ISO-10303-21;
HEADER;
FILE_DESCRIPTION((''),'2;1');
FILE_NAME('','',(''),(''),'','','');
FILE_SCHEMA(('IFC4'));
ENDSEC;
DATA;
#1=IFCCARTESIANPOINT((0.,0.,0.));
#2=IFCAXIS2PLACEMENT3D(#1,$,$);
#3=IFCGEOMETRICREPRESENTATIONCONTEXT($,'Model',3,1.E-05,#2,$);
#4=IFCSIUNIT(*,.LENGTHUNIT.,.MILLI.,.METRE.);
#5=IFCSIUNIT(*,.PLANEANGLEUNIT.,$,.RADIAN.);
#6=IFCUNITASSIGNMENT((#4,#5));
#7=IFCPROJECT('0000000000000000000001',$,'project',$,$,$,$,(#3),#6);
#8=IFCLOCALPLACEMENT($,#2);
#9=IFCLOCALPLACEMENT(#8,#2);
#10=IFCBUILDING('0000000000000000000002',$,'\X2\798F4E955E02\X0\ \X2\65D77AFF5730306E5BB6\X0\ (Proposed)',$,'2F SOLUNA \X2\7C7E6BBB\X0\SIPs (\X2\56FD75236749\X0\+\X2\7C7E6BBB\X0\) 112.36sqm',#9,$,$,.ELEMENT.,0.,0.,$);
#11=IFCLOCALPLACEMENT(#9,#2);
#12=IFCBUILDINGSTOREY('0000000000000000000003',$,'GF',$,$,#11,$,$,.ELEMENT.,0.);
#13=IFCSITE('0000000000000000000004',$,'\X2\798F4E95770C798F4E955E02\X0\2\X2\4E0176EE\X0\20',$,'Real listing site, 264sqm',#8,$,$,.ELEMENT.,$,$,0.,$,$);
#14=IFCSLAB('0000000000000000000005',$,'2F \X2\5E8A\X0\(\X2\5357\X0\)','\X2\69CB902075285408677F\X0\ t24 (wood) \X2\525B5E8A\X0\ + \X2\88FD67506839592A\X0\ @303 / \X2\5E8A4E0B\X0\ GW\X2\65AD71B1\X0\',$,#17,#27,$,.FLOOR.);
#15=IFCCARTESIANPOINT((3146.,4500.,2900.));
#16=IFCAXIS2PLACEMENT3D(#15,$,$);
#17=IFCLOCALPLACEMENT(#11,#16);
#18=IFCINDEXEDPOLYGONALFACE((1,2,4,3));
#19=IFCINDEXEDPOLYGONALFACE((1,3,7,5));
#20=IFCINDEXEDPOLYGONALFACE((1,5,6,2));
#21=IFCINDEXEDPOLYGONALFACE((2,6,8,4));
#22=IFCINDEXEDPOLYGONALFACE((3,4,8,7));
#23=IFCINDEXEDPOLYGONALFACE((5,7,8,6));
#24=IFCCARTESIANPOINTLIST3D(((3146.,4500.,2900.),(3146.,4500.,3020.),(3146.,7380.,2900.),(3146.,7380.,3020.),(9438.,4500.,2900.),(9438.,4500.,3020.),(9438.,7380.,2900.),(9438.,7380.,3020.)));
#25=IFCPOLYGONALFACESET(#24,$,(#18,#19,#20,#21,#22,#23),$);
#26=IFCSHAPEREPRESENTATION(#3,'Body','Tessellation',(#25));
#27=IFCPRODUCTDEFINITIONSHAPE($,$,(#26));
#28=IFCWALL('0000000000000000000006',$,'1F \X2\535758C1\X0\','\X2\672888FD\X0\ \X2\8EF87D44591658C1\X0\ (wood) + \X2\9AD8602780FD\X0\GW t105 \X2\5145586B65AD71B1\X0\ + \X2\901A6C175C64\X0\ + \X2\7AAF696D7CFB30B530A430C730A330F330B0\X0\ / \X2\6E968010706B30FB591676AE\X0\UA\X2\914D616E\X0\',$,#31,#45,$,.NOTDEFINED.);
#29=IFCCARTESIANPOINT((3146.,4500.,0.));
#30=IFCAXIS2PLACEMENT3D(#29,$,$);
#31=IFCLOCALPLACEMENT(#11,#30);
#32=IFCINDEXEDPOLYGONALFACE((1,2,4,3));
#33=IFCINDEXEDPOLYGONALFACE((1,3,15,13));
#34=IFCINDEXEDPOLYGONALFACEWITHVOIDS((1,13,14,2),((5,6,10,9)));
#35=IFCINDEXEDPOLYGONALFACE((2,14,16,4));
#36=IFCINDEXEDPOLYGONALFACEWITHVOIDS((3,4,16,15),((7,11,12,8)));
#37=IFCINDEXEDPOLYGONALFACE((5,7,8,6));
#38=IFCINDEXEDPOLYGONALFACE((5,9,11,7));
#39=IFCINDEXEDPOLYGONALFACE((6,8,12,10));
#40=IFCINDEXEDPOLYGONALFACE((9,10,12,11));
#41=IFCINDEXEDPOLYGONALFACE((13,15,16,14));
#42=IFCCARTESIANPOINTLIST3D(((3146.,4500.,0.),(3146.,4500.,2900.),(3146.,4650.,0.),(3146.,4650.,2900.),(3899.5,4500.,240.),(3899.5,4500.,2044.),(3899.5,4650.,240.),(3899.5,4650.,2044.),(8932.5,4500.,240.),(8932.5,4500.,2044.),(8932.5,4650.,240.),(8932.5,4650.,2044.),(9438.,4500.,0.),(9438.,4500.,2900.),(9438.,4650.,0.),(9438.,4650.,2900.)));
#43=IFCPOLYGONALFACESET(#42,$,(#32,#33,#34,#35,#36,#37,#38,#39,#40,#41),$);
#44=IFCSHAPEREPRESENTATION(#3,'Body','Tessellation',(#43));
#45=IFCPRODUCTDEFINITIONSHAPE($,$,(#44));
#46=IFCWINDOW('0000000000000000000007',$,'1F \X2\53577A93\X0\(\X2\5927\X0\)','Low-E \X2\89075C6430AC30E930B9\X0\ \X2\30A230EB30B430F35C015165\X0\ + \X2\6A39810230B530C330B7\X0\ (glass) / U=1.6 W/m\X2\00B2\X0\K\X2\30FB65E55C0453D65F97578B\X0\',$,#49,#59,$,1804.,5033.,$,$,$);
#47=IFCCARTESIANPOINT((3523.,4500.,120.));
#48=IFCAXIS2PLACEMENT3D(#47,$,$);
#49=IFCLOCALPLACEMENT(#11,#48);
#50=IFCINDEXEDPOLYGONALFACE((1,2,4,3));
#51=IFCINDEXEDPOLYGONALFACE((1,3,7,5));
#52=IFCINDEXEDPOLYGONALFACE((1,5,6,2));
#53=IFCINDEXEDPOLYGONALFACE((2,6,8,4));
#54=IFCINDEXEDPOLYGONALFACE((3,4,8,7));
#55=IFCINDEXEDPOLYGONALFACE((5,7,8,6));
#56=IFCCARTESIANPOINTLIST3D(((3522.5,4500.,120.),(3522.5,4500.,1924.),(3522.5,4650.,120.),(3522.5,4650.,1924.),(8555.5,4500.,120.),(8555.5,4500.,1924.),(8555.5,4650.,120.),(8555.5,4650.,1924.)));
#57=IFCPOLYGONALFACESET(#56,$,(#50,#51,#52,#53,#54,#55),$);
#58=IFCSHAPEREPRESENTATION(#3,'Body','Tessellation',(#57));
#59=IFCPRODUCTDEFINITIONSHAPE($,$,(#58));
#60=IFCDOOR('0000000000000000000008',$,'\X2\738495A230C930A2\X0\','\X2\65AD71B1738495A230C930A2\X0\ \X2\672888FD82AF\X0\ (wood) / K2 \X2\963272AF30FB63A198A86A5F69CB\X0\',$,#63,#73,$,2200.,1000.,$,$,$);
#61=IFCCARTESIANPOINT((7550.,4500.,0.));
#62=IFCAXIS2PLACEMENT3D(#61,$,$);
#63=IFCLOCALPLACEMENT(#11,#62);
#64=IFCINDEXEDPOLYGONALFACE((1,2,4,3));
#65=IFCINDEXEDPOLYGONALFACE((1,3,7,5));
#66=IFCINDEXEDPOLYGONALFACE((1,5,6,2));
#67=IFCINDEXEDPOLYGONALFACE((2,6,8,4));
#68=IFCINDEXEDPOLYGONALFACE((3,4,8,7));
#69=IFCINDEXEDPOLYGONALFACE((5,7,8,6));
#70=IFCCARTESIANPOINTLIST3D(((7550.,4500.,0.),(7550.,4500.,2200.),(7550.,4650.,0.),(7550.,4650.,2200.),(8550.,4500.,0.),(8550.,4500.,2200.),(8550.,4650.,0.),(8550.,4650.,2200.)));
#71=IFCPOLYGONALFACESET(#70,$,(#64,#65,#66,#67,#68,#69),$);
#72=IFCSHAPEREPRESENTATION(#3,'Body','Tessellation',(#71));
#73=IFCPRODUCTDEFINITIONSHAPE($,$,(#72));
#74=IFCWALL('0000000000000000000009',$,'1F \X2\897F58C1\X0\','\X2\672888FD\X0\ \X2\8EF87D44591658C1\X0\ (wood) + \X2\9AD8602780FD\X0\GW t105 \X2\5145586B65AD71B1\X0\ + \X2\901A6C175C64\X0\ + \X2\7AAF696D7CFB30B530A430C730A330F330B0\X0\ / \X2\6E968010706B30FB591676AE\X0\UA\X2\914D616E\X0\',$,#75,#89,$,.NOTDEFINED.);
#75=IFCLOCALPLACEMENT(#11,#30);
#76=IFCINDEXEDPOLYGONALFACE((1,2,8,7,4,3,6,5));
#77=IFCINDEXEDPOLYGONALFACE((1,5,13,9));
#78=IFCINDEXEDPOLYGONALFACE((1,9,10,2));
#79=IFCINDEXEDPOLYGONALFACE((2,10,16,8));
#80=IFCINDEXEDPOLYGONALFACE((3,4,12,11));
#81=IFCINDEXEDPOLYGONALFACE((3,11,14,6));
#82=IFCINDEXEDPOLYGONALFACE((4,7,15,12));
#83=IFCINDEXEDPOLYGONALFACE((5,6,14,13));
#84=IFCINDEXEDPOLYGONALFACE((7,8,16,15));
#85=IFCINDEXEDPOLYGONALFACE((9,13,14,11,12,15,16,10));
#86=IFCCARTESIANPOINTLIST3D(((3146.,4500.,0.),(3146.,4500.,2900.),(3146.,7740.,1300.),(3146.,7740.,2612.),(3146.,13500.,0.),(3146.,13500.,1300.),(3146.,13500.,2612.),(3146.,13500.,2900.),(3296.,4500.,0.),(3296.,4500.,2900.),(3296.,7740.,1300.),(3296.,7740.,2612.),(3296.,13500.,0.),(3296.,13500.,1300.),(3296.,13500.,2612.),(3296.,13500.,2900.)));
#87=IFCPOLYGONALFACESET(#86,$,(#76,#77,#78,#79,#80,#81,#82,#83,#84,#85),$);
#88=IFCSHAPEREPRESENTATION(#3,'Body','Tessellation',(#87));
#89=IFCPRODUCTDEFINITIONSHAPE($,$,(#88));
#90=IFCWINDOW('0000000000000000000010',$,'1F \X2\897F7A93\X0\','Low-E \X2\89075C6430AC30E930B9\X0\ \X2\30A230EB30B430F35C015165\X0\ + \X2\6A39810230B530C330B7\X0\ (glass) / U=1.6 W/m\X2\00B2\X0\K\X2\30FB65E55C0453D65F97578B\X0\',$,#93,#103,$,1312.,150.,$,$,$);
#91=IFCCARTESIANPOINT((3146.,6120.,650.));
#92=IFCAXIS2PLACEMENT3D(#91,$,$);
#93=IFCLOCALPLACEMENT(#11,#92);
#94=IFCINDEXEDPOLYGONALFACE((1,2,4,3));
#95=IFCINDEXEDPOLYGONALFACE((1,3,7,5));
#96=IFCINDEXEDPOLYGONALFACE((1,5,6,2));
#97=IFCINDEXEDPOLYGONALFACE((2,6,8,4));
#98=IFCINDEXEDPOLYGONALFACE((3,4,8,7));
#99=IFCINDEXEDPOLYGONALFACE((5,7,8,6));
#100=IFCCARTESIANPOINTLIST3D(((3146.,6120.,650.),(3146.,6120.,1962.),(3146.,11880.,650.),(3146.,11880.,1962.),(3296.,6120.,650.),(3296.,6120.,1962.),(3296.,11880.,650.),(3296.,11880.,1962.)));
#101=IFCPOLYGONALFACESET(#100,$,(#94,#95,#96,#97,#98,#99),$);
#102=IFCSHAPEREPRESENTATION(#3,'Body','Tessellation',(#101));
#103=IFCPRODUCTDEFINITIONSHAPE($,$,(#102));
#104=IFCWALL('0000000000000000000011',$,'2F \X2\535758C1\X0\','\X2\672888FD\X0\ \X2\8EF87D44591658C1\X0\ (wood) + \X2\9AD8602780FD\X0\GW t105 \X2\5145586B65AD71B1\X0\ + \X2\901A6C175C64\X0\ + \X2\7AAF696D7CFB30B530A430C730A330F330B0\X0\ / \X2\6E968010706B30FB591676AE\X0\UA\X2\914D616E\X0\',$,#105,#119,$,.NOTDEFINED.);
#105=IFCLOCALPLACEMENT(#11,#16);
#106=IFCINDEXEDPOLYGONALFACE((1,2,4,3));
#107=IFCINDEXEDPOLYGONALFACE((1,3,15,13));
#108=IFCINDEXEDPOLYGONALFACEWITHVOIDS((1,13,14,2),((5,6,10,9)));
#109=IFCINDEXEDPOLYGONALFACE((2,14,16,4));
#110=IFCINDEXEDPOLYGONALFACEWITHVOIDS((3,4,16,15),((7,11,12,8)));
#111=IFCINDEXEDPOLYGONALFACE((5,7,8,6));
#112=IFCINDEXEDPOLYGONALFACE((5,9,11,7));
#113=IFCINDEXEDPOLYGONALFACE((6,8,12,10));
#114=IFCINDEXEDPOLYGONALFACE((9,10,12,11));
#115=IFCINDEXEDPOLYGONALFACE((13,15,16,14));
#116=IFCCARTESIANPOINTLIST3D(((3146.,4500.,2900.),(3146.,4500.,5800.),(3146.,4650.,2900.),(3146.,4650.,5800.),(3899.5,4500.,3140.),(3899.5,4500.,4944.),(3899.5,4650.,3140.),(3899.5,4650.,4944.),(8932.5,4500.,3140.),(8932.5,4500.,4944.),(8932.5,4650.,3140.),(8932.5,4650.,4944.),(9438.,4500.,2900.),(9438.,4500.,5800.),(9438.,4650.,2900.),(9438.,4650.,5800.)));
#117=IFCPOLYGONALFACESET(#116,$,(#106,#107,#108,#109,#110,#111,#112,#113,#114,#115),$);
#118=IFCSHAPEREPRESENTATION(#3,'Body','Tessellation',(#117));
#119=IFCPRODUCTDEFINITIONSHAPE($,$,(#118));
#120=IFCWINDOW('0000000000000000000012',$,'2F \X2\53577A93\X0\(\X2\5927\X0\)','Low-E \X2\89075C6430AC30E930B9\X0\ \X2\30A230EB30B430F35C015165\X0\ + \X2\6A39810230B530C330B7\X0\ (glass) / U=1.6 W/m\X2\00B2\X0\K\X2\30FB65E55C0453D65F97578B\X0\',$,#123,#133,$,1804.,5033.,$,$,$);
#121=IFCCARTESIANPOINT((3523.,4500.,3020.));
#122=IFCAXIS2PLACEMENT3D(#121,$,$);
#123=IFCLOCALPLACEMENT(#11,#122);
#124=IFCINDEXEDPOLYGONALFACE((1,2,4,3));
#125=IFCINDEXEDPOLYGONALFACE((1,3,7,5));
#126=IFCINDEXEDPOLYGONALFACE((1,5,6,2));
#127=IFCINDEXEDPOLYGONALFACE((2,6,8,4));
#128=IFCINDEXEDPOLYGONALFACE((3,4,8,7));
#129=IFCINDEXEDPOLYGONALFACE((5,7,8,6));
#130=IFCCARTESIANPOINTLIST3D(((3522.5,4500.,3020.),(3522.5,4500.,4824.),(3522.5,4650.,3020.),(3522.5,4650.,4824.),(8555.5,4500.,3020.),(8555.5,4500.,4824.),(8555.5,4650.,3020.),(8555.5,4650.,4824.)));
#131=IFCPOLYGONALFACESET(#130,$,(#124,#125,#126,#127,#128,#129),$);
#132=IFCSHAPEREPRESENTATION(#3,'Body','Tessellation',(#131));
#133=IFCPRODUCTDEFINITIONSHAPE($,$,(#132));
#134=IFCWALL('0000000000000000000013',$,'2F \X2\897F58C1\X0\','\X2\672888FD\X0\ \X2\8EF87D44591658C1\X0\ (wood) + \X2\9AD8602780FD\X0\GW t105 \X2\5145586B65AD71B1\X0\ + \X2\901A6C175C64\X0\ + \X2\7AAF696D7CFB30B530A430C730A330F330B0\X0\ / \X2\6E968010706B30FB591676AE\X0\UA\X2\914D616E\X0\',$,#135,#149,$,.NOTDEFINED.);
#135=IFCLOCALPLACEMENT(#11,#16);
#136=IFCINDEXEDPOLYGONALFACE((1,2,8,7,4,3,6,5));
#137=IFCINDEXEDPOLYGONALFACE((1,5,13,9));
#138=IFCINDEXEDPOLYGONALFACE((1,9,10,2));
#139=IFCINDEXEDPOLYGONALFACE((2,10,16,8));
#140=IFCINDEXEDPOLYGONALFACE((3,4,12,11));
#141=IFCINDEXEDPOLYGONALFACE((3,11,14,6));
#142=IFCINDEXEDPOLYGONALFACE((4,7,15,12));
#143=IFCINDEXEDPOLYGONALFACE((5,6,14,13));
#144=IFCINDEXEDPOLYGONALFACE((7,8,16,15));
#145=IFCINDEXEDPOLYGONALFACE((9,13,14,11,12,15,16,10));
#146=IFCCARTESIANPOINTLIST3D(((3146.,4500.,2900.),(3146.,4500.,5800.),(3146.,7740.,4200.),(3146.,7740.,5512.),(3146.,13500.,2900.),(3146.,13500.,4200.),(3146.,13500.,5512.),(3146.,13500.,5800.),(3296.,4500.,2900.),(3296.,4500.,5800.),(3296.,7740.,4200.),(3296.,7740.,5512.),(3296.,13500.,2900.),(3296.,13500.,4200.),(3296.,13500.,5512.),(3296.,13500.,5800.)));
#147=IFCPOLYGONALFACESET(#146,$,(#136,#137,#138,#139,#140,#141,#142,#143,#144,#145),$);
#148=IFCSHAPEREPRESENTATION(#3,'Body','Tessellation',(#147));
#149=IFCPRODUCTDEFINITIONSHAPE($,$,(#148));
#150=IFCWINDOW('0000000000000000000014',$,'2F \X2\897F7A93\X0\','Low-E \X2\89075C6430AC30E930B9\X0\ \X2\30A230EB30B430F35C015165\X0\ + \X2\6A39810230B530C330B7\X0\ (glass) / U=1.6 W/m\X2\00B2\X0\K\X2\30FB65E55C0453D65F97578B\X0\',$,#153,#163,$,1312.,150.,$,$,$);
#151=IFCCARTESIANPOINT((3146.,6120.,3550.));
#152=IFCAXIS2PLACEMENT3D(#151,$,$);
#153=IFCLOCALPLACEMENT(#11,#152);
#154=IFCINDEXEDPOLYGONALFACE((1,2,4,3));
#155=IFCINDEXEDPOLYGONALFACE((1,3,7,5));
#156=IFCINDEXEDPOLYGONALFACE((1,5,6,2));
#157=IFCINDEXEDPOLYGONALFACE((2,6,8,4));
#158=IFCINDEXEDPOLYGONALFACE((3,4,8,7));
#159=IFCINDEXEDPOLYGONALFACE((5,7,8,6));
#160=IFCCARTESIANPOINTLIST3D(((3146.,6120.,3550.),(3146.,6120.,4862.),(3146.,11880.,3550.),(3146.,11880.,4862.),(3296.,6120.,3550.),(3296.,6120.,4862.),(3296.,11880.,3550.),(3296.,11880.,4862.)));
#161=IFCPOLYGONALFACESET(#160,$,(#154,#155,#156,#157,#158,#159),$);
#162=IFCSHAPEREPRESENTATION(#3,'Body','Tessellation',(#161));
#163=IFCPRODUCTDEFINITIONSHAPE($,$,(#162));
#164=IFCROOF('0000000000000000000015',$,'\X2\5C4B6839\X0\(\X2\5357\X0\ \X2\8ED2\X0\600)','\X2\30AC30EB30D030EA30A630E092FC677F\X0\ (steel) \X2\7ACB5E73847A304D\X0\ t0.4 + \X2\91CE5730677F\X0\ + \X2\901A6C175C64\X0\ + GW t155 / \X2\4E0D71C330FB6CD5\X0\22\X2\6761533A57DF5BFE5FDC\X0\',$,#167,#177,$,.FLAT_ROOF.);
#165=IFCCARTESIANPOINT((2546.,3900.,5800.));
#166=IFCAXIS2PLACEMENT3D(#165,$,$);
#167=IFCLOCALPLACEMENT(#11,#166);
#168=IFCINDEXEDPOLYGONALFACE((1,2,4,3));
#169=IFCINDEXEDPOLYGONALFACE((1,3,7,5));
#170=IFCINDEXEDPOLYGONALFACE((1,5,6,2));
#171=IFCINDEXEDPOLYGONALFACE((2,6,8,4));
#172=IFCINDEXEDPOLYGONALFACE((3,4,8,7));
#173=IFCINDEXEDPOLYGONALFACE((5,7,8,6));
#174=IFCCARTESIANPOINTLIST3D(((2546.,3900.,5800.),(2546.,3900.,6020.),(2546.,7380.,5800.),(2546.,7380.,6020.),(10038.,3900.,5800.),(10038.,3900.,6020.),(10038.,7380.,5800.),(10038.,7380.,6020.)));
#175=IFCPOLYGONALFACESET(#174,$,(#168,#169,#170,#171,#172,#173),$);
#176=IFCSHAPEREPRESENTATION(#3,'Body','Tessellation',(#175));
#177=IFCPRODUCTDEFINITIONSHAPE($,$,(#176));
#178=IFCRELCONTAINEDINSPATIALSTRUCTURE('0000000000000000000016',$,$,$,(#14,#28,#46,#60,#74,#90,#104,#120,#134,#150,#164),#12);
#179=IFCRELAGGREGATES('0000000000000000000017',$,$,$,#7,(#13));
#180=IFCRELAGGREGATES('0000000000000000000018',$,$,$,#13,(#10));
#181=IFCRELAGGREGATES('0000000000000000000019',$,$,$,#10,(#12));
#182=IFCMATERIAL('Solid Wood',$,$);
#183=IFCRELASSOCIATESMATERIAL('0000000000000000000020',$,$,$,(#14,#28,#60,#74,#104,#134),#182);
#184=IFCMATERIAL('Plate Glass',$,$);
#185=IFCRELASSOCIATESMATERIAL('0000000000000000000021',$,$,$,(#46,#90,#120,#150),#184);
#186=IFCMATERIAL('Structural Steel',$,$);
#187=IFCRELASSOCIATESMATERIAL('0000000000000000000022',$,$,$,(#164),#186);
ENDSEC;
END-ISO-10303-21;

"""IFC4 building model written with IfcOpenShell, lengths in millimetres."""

from ifc_helpers import new_model, si_unit, frame, frame_2d, origin, place, context, project, spatial, rectangle, extrude, material, element, fill, save


model = new_model("IFC4")

# Units and contexts
model_context = context("Model", 3, precision=1e-05, world=origin())
ifc_project = project(units=[si_unit("LENGTHUNIT", "METRE", prefix="MILLI"), si_unit("PLANEANGLEUNIT", "RADIAN")], contexts=[model_context])

# Site, building, storey
site_placement = place(None, origin())
site = spatial("IfcSite", under=ifc_project, at=site_placement, Name="福井県福井市2丁目20", ObjectType="Real listing site, 264sqm", CompositionType="ELEMENT", RefElevation=0.0)
building_placement = place(site_placement, origin())
building = spatial("IfcBuilding", under=site, at=building_placement, Name="福井市 旗竿地の家 (Proposed)", ObjectType="2F SOLUNA 籾殻SIPs (国産杉+籾殻) 112.36sqm", CompositionType="ELEMENT", ElevationOfRefHeight=0.0, ElevationOfTerrain=0.0)
storey_placement = place(building_placement, origin())
storey = spatial("IfcBuildingStorey", under=building, at=storey_placement, Name="GF", CompositionType="ELEMENT", Elevation=0.0)

# Slab
ifc_material_1 = material(Name="Solid Wood")
slab_1_placement = place(storey_placement, frame((3146.0, 4500.0, 2900.0)))
element("IfcSlab", 1, at=slab_1_placement, inside=storey, material=ifc_material_1, Name="2F 床(南)", Description="構造用合板 t24 (wood) 剛床 + 製材根太 @303 / 床下 GW断熱", PredefinedType="FLOOR", context=model_context, shape_type="SweptSolid", body=[
    extrude(rectangle(XDim=6292.0, YDim=2880.0, at=frame_2d((3146.0, 1440.0))), frame((3146.0, 4500.0, 2900.0)), (0.0, 0.0, 1.0), 120.0),
])

# Wall, openings, window, door
wall_1_placement = place(storey_placement, frame((3146.0, 4500.0, 0.0)))
wall_1 = element("IfcWall", 2, at=wall_1_placement, inside=storey, material=ifc_material_1, Name="1F 南壁", Description="木製 軸組外壁 (wood) + 高性能GW t105 充填断熱 + 通気層 + 窯業系サイディング / 準耐火・外皮UA配慮", PredefinedType="NOTDEFINED", context=model_context, shape_type="SweptSolid", body=[
    extrude(rectangle(XDim=6292.0, YDim=150.0, at=frame_2d((3146.0, 75.0))), frame((3146.0, 4500.0, 0.0)), (0.0, 0.0, 1.0), 2900.0),
])
opening_1_placement = place(storey_placement, frame((3523.0, 4500.0, 120.0)))
opening_1 = element("IfcOpeningElement", 3, at=opening_1_placement, cuts=wall_1, PredefinedType="NOTDEFINED", context=model_context, shape_type="SweptSolid", body=[
    extrude(rectangle(XDim=5033.0, YDim=150.0, at=frame_2d((2516.0, 75.0))), frame((3523.0, 4500.0, 120.0)), (0.0, 0.0, 1.0), 1804.0),
])
opening_2_placement = place(storey_placement, frame((7550.0, 4500.0, 0.0)))
opening_2 = element("IfcOpeningElement", 4, at=opening_2_placement, cuts=wall_1, PredefinedType="NOTDEFINED", context=model_context, shape_type="SweptSolid", body=[
    extrude(rectangle(XDim=1000.0, YDim=150.0, at=frame_2d((500.0, 75.0))), frame((7550.0, 4500.0, 0.0)), (0.0, 0.0, 1.0), 2200.0),
])
ifc_material_2 = material(Name="Plate Glass")
window_1_placement = place(storey_placement, frame((3523.0, 4500.0, 120.0)))
window_1 = element("IfcWindow", 5, at=window_1_placement, inside=storey, material=ifc_material_2, Name="1F 南窓(大)", Description="Low-E 複層ガラス アルゴン封入 + 樹脂サッシ (glass) / U=1.6 W/m²K・日射取得型", OverallHeight=1804.0, OverallWidth=5033.0, context=model_context, shape_type="SweptSolid", body=[
    extrude(rectangle(XDim=5033.0, YDim=150.0, at=frame_2d((2516.0, 75.0))), frame((3523.0, 4500.0, 120.0)), (0.0, 0.0, 1.0), 1804.0),
])
fill(opening_1, window_1)
door_placement = place(storey_placement, frame((7550.0, 4500.0, 0.0)))
door = element("IfcDoor", 6, at=door_placement, inside=storey, material=ifc_material_1, Name="玄関ドア", Description="断熱玄関ドア 木製芯 (wood) / K2 防犯・採風機構", OverallHeight=2200.0, OverallWidth=1000.0, context=model_context, shape_type="SweptSolid", body=[
    extrude(rectangle(XDim=1000.0, YDim=150.0, at=frame_2d((500.0, 75.0))), frame((7550.0, 4500.0, 0.0)), (0.0, 0.0, 1.0), 2200.0),
])
fill(opening_2, door)

# Walls, openings, windows
wall_2_placement = place(storey_placement, frame((3146.0, 4500.0, 0.0)))
wall_2 = element("IfcWall", 7, at=wall_2_placement, inside=storey, material=ifc_material_1, Name="1F 西壁", Description="木製 軸組外壁 (wood) + 高性能GW t105 充填断熱 + 通気層 + 窯業系サイディング / 準耐火・外皮UA配慮", PredefinedType="NOTDEFINED", context=model_context, shape_type="SweptSolid", body=[
    extrude(rectangle(XDim=150.0, YDim=9000.0, at=frame_2d((75.0, 4500.0))), frame((3146.0, 4500.0, 0.0)), (0.0, 0.0, 1.0), 2900.0),
])
opening_3_placement = place(storey_placement, frame((3146.0, 6120.0, 650.0)))
opening_3 = element("IfcOpeningElement", 8, at=opening_3_placement, cuts=wall_2, PredefinedType="NOTDEFINED", context=model_context, shape_type="SweptSolid", body=[
    extrude(rectangle(XDim=150.0, YDim=5760.0, at=frame_2d((75.0, 2880.0))), frame((3146.0, 6120.0, 650.0)), (0.0, 0.0, 1.0), 1312.0),
])
window_2_placement = place(storey_placement, frame((3146.0, 6120.0, 650.0)))
window_2 = element("IfcWindow", 9, at=window_2_placement, inside=storey, material=ifc_material_2, Name="1F 西窓", Description="Low-E 複層ガラス アルゴン封入 + 樹脂サッシ (glass) / U=1.6 W/m²K・日射取得型", OverallHeight=1312.0, OverallWidth=150.0, context=model_context, shape_type="SweptSolid", body=[
    extrude(rectangle(XDim=150.0, YDim=5760.0, at=frame_2d((75.0, 2880.0))), frame((3146.0, 6120.0, 650.0)), (0.0, 0.0, 1.0), 1312.0),
])
fill(opening_3, window_2)
wall_3_placement = place(storey_placement, frame((3146.0, 4500.0, 2900.0)))
wall_3 = element("IfcWall", 10, at=wall_3_placement, inside=storey, material=ifc_material_1, Name="2F 南壁", Description="木製 軸組外壁 (wood) + 高性能GW t105 充填断熱 + 通気層 + 窯業系サイディング / 準耐火・外皮UA配慮", PredefinedType="NOTDEFINED", context=model_context, shape_type="SweptSolid", body=[
    extrude(rectangle(XDim=6292.0, YDim=150.0, at=frame_2d((3146.0, 75.0))), frame((3146.0, 4500.0, 2900.0)), (0.0, 0.0, 1.0), 2900.0),
])
opening_4_placement = place(storey_placement, frame((3523.0, 4500.0, 3020.0)))
opening_4 = element("IfcOpeningElement", 11, at=opening_4_placement, cuts=wall_3, PredefinedType="NOTDEFINED", context=model_context, shape_type="SweptSolid", body=[
    extrude(rectangle(XDim=5033.0, YDim=150.0, at=frame_2d((2516.0, 75.0))), frame((3523.0, 4500.0, 3020.0)), (0.0, 0.0, 1.0), 1804.0),
])
window_3_placement = place(storey_placement, frame((3523.0, 4500.0, 3020.0)))
window_3 = element("IfcWindow", 12, at=window_3_placement, inside=storey, material=ifc_material_2, Name="2F 南窓(大)", Description="Low-E 複層ガラス アルゴン封入 + 樹脂サッシ (glass) / U=1.6 W/m²K・日射取得型", OverallHeight=1804.0, OverallWidth=5033.0, context=model_context, shape_type="SweptSolid", body=[
    extrude(rectangle(XDim=5033.0, YDim=150.0, at=frame_2d((2516.0, 75.0))), frame((3523.0, 4500.0, 3020.0)), (0.0, 0.0, 1.0), 1804.0),
])
fill(opening_4, window_3)
wall_4_placement = place(storey_placement, frame((3146.0, 4500.0, 2900.0)))
wall_4 = element("IfcWall", 13, at=wall_4_placement, inside=storey, material=ifc_material_1, Name="2F 西壁", Description="木製 軸組外壁 (wood) + 高性能GW t105 充填断熱 + 通気層 + 窯業系サイディング / 準耐火・外皮UA配慮", PredefinedType="NOTDEFINED", context=model_context, shape_type="SweptSolid", body=[
    extrude(rectangle(XDim=150.0, YDim=9000.0, at=frame_2d((75.0, 4500.0))), frame((3146.0, 4500.0, 2900.0)), (0.0, 0.0, 1.0), 2900.0),
])
opening_5_placement = place(storey_placement, frame((3146.0, 6120.0, 3550.0)))
opening_5 = element("IfcOpeningElement", 14, at=opening_5_placement, cuts=wall_4, PredefinedType="NOTDEFINED", context=model_context, shape_type="SweptSolid", body=[
    extrude(rectangle(XDim=150.0, YDim=5760.0, at=frame_2d((75.0, 2880.0))), frame((3146.0, 6120.0, 3550.0)), (0.0, 0.0, 1.0), 1312.0),
])
window_4_placement = place(storey_placement, frame((3146.0, 6120.0, 3550.0)))
window_4 = element("IfcWindow", 15, at=window_4_placement, inside=storey, material=ifc_material_2, Name="2F 西窓", Description="Low-E 複層ガラス アルゴン封入 + 樹脂サッシ (glass) / U=1.6 W/m²K・日射取得型", OverallHeight=1312.0, OverallWidth=150.0, context=model_context, shape_type="SweptSolid", body=[
    extrude(rectangle(XDim=150.0, YDim=5760.0, at=frame_2d((75.0, 2880.0))), frame((3146.0, 6120.0, 3550.0)), (0.0, 0.0, 1.0), 1312.0),
])
fill(opening_5, window_4)

# Roof
ifc_material_3 = material(Name="Structural Steel")
roof_1_placement = place(storey_placement, frame((2546.0, 3900.0, 5800.0)))
element("IfcRoof", 16, at=roof_1_placement, inside=storey, material=ifc_material_3, Name="屋根(南 軒600)", Description="ガルバリウム鋼板 (steel) 立平葺き t0.4 + 野地板 + 通気層 + GW t155 / 不燃・法22条区域対応", PredefinedType="FLAT_ROOF", context=model_context, shape_type="SweptSolid", body=[
    extrude(rectangle(XDim=7492.0, YDim=3480.0, at=frame_2d((3746.0, 1740.0))), frame((2546.0, 3900.0, 5800.0)), (0.0, 0.0, 1.0), 220.0),
])

save(model, "model.ifc")
